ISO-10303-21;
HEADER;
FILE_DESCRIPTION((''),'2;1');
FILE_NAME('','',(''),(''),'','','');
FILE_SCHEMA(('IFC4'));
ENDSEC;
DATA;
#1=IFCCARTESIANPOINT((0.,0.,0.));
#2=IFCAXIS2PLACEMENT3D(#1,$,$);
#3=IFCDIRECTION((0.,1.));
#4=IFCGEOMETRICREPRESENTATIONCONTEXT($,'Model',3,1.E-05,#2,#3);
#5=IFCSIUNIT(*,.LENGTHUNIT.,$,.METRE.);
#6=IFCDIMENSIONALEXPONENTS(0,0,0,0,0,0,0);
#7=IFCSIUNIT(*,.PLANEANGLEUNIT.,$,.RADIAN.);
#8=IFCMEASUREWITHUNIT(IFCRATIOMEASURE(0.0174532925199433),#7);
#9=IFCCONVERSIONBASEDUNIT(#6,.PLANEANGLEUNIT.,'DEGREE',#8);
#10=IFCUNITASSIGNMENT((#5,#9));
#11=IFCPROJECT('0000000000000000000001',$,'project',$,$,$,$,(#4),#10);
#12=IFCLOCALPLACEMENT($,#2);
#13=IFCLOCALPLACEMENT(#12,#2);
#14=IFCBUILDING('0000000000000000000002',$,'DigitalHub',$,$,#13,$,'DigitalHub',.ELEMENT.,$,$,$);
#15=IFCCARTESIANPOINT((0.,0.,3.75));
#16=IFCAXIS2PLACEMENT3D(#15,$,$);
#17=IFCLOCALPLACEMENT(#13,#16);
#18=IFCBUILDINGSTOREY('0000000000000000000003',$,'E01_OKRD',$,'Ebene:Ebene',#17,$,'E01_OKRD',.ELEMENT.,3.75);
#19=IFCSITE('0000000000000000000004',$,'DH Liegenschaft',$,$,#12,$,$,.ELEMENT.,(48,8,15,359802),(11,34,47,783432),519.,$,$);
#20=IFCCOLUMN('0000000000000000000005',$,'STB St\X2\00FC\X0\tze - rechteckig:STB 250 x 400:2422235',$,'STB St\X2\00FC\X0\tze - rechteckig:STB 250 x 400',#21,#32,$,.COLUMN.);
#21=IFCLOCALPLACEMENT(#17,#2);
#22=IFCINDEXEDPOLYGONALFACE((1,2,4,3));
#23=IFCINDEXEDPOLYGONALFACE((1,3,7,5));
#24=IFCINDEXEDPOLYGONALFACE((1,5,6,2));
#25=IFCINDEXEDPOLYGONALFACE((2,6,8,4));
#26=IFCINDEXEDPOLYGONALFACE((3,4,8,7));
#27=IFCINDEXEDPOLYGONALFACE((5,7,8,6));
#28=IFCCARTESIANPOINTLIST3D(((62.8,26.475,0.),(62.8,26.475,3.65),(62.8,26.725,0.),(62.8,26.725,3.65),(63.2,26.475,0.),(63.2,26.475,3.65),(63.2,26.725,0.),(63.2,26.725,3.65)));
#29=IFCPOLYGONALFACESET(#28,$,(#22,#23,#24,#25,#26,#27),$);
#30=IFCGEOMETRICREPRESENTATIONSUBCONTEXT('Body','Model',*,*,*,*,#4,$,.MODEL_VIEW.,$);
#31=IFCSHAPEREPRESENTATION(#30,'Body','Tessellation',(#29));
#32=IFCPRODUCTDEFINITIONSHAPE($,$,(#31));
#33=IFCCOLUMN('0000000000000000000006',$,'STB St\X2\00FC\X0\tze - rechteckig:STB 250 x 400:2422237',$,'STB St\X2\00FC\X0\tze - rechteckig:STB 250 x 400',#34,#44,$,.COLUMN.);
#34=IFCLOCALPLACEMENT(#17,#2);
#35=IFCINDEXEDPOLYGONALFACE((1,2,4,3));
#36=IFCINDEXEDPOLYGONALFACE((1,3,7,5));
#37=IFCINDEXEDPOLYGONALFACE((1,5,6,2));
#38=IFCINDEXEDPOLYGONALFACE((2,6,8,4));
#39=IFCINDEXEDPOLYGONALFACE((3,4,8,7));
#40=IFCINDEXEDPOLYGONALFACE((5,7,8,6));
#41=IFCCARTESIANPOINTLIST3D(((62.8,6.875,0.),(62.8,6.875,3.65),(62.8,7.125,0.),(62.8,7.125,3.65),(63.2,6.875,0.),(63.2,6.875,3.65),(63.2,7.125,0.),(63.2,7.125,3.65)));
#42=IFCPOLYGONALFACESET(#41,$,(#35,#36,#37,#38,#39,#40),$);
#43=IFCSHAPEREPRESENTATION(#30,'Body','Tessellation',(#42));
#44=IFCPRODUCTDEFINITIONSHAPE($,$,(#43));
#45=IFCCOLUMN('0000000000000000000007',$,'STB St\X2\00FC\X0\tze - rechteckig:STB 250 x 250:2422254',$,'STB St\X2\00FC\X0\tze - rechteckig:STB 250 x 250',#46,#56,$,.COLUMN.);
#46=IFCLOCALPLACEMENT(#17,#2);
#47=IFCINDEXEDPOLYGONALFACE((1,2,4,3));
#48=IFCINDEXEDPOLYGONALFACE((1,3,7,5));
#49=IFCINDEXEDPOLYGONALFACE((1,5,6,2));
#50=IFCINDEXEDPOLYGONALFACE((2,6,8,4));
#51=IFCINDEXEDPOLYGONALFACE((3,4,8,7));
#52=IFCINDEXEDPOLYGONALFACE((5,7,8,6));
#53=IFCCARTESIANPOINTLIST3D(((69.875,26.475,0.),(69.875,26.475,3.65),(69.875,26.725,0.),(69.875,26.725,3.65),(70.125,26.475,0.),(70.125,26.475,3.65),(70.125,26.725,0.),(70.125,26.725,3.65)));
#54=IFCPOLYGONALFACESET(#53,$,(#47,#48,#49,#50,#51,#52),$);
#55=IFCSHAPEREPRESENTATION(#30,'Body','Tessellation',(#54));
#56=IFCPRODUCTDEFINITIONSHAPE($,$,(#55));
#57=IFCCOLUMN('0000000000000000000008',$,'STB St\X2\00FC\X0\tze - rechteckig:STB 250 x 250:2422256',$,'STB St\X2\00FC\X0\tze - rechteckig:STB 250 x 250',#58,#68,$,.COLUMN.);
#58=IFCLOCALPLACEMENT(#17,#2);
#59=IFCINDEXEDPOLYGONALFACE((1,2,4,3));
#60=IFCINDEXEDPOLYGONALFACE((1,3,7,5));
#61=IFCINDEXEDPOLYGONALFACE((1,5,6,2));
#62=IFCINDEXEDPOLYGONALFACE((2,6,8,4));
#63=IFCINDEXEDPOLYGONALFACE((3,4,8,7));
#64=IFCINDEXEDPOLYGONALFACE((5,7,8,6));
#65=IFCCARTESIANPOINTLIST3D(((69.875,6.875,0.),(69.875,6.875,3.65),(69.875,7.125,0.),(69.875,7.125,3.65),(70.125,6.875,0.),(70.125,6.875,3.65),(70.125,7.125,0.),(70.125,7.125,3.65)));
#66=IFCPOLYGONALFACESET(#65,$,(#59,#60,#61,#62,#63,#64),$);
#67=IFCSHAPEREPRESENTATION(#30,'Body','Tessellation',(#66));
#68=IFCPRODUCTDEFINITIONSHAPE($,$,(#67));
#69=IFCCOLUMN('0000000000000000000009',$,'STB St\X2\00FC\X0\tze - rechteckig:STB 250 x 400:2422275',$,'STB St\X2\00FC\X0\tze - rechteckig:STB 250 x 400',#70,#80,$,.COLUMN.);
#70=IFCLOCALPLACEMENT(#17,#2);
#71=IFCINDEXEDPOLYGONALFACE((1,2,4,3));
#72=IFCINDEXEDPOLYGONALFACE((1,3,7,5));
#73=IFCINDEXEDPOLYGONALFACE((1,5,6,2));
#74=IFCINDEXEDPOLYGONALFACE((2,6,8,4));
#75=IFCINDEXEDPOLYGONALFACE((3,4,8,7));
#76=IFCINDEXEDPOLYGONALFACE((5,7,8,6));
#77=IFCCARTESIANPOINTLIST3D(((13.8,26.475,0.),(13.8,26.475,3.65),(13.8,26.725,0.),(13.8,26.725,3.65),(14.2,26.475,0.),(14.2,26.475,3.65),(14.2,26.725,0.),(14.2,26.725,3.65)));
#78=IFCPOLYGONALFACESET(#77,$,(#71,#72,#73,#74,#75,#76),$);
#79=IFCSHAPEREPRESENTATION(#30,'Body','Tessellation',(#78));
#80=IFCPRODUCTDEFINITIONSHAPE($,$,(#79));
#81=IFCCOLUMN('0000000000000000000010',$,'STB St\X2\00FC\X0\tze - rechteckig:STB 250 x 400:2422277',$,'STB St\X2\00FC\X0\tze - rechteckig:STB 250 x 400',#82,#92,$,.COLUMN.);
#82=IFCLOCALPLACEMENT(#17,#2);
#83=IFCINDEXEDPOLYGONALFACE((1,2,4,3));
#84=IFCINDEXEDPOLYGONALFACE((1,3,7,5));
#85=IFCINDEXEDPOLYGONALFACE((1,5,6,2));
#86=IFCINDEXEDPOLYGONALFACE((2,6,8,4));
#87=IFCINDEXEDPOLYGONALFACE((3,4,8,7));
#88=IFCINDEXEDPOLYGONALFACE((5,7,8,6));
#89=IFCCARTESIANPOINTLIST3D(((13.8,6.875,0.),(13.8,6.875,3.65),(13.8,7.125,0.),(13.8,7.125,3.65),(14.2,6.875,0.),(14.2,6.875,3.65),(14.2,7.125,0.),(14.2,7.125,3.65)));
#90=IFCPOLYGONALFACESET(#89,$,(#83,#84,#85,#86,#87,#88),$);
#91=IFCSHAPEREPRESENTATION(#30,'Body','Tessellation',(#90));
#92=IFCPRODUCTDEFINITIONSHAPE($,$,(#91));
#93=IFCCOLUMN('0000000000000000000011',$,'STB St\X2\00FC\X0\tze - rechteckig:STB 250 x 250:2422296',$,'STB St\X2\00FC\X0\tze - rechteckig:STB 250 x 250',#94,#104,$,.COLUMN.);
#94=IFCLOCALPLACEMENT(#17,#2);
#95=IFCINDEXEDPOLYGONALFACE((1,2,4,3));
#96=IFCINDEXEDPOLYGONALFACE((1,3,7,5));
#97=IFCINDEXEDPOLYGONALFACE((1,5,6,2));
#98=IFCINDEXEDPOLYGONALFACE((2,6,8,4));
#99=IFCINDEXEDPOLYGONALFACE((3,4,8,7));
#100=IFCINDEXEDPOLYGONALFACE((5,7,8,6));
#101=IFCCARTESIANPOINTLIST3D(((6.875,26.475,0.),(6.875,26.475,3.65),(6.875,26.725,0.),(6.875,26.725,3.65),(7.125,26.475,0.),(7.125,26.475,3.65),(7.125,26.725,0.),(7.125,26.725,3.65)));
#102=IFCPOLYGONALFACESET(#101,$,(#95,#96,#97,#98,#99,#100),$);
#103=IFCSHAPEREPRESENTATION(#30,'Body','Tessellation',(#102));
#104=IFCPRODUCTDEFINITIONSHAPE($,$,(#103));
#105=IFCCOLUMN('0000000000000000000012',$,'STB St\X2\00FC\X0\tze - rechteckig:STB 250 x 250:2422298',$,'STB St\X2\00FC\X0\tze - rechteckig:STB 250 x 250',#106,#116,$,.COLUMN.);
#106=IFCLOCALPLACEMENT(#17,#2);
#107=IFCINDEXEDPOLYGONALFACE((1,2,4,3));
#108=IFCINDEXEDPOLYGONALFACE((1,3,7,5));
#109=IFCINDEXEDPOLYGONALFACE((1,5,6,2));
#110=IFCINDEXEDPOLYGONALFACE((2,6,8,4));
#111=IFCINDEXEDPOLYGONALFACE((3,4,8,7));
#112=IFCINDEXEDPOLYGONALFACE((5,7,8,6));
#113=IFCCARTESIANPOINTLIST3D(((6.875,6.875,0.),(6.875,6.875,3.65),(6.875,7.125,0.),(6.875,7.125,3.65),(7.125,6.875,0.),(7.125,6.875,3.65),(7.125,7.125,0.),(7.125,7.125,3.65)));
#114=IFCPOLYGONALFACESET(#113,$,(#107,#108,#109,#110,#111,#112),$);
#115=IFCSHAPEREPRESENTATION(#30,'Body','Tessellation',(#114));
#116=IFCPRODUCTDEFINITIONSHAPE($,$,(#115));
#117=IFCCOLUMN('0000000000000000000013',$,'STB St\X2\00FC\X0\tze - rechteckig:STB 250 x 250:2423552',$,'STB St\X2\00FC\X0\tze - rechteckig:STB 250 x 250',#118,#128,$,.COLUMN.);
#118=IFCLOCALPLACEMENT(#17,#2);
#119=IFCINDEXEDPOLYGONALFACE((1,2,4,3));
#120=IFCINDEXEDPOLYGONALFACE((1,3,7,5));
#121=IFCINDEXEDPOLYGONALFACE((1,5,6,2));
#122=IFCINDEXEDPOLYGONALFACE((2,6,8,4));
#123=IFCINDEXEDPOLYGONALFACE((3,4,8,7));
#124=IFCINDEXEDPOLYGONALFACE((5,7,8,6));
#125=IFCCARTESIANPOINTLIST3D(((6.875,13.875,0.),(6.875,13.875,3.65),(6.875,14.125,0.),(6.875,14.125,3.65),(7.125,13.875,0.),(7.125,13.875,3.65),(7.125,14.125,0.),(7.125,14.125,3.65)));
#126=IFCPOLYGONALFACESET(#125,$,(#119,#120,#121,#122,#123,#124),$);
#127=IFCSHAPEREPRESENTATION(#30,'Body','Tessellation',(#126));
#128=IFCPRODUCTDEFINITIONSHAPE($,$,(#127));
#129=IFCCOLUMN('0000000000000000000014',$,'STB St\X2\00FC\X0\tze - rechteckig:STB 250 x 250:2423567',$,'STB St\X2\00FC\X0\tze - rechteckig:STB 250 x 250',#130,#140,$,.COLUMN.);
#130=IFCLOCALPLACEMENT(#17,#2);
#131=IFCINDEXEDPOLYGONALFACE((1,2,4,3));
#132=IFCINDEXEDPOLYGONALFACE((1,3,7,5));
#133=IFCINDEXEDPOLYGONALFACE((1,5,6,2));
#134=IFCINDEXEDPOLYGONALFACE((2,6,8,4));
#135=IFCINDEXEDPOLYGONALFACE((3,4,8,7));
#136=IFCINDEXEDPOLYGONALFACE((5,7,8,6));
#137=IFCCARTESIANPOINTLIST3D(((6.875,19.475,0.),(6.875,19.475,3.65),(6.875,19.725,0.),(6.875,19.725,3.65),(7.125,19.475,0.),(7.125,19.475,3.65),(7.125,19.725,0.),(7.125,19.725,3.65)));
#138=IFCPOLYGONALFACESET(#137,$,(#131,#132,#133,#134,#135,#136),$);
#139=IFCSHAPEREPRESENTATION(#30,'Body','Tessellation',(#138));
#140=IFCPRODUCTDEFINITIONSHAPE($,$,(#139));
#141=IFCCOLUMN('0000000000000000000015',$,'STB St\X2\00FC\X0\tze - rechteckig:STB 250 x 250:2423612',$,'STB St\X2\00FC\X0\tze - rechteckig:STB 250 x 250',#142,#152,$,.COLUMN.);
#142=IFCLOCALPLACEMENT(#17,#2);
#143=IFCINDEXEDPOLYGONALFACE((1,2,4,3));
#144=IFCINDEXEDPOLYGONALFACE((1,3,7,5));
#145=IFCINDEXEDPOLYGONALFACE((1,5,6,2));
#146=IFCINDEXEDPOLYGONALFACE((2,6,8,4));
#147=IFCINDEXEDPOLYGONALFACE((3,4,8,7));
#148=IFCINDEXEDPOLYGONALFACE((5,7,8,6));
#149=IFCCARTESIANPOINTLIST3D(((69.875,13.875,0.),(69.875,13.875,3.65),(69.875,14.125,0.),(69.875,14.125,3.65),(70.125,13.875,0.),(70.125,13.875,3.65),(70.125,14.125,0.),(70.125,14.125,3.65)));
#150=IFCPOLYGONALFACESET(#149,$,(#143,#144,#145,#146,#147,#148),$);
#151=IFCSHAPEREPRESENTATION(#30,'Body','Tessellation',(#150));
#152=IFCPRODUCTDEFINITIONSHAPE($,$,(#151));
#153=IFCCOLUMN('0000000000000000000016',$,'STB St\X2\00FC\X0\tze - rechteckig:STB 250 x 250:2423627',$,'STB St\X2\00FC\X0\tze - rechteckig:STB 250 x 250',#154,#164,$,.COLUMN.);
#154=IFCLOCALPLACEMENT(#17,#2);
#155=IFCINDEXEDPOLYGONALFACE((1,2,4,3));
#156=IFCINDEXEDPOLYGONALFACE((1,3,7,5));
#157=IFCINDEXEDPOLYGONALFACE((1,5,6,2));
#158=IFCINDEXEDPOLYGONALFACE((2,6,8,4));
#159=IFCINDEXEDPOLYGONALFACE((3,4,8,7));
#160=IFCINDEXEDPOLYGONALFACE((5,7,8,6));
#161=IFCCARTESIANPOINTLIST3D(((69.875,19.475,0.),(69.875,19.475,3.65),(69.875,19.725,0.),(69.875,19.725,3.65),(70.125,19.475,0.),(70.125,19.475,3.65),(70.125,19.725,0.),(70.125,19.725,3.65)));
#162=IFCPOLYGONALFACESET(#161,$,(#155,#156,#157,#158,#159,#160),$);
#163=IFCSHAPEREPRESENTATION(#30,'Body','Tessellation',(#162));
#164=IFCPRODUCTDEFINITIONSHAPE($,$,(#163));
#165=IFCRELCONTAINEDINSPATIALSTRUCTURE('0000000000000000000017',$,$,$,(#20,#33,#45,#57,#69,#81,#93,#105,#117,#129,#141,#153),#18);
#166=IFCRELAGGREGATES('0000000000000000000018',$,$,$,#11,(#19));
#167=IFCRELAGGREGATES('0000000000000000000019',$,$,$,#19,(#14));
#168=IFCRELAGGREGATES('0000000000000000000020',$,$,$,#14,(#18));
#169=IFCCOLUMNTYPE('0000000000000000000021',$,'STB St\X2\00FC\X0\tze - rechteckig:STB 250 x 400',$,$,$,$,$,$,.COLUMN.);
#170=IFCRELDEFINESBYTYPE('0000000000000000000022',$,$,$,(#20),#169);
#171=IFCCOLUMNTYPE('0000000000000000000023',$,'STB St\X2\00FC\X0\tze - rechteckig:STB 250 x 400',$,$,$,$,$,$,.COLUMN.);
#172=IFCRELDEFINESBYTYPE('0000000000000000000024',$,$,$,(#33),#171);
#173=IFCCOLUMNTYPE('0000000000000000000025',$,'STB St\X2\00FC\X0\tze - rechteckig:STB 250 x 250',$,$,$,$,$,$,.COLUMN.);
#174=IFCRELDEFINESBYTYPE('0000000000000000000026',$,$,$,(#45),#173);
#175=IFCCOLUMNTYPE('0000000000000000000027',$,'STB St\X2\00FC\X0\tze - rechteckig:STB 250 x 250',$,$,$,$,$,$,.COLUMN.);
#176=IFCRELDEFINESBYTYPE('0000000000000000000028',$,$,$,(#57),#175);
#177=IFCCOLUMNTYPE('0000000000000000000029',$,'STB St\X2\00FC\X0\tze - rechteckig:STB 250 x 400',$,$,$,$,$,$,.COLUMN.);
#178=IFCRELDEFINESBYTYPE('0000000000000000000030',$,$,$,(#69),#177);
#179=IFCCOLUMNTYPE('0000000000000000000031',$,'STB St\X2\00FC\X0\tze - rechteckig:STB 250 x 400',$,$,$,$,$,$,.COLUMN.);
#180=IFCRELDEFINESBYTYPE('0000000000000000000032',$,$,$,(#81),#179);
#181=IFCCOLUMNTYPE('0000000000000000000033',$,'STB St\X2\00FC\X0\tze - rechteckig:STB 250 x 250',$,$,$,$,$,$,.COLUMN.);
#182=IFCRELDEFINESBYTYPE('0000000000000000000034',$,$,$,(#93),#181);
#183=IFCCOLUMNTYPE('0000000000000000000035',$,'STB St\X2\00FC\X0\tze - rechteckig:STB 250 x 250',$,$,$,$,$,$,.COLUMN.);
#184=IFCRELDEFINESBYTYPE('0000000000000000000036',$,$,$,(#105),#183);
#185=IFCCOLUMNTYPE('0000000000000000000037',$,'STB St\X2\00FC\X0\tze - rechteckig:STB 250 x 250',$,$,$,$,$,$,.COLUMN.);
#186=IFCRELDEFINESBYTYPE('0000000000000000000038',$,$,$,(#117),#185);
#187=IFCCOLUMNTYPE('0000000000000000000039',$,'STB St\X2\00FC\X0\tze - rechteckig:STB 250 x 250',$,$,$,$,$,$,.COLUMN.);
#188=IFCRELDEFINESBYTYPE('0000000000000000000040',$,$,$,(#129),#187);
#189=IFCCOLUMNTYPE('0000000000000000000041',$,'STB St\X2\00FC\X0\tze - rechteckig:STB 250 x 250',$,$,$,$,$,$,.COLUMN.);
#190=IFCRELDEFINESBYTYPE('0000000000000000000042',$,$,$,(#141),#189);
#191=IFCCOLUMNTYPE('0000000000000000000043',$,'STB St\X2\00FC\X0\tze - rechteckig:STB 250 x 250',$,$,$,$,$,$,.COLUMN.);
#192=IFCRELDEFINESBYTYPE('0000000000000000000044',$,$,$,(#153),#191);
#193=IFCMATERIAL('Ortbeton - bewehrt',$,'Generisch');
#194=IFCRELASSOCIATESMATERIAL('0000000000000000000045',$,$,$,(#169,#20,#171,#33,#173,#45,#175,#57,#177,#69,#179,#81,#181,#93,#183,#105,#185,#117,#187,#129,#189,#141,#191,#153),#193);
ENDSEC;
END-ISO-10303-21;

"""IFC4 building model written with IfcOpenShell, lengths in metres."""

from ifc_helpers import new_model, entity, si_unit, converted_unit, direction, frame, origin, place, context, subcontext, project, spatial, indexed_curve, outline, extrude, source, transform, mapped, material, type_object, type_shapes, element, save


model = new_model("IFC4")

# Units and contexts
model_context = context("Model", 3, precision=1e-05, world=origin(), true_north=direction((0.0, 1.0)))
body_context = subcontext(model_context, "Body", "Model", "MODEL_VIEW")
ifc_project = project(units=[si_unit("LENGTHUNIT", "METRE"), converted_unit("PLANEANGLEUNIT", "DEGREE", entity("IfcRatioMeasure", 0.0174532925199433), si_unit("PLANEANGLEUNIT", "RADIAN"), dimensions=[0, 0, 0, 0, 0, 0, 0])], contexts=[model_context])

# Site, building, storey
site_placement = place(None, frame((0.0, 0.0, 0.0)))
site = spatial("IfcSite", under=ifc_project, at=site_placement, Name="DH Liegenschaft", CompositionType="ELEMENT", RefLatitude=(48, 8, 15, 359802), RefLongitude=(11, 34, 47, 783432), RefElevation=519.0)
building_placement = place(site_placement, origin())
building = spatial("IfcBuilding", under=site, at=building_placement, Name="DigitalHub", LongName="DigitalHub", CompositionType="ELEMENT")
storey_placement = place(building_placement, frame((0.0, 0.0, 3.75)))
storey = spatial("IfcBuildingStorey", under=building, at=storey_placement, Name="E01_OKRD", ObjectType="Ebene:Ebene", LongName="E01_OKRD", CompositionType="ELEMENT", Elevation=3.75)

# Columns
ifc_material_1 = material(Name="Ortbeton - bewehrt", Category="Generisch")
column_type_1 = type_object("IfcColumnType", Name="STB Stütze - rechteckig:STB 250 x 400", PredefinedType="COLUMN", material=ifc_material_1)
shared_shape_1 = source(origin(), body_context, "Body", "SweptSolid", [
    extrude(outline(indexed_curve([(-0.125, -0.2), (0.125, -0.2), (0.125, 0.2), (-0.125, 0.2), (-0.125, -0.2)], self_intersect=False)), frame((63.0, 26.6, 3.75), z_axis=(0.0, 0.0, 1.0), x_axis=(0.0, -1.0, 0.0)), (0.0, 0.0, 1.0), 3.65),
])
type_shapes(column_type_1, [shared_shape_1])
column_1_placement = place(storey_placement, frame((0.0, 0.0, -3.75)))
element("IfcColumn", 1, at=column_1_placement, inside=storey, type_object=column_type_1, material=ifc_material_1, Name="STB Stütze - rechteckig:STB 250 x 400:2422235", ObjectType="STB Stütze - rechteckig:STB 250 x 400", PredefinedType="COLUMN", context=body_context, shape_type="MappedRepresentation", body=[
    mapped(shared_shape_1, transform((0.0, 0.0, 0.0), scale=1.0)),
])
column_type_2 = type_object("IfcColumnType", Name="STB Stütze - rechteckig:STB 250 x 400", PredefinedType="COLUMN", material=ifc_material_1)
shared_shape_2 = source(origin(), body_context, "Body", "SweptSolid", [
    extrude(outline(indexed_curve([(-0.125, -0.2), (0.125, -0.2), (0.125, 0.2), (-0.125, 0.2), (-0.125, -0.2)], self_intersect=False)), frame((63.0, 7.0, 3.75), z_axis=(0.0, 0.0, 1.0), x_axis=(0.0, -1.0, 0.0)), (0.0, 0.0, 1.0), 3.65),
])
type_shapes(column_type_2, [shared_shape_2])
column_2_placement = place(storey_placement, frame((0.0, 0.0, -3.75)))
element("IfcColumn", 2, at=column_2_placement, inside=storey, type_object=column_type_2, material=ifc_material_1, Name="STB Stütze - rechteckig:STB 250 x 400:2422237", ObjectType="STB Stütze - rechteckig:STB 250 x 400", PredefinedType="COLUMN", context=body_context, shape_type="MappedRepresentation", body=[
    mapped(shared_shape_2, transform((0.0, 0.0, 0.0), scale=1.0)),
])
column_type_3 = type_object("IfcColumnType", Name="STB Stütze - rechteckig:STB 250 x 250", PredefinedType="COLUMN", material=ifc_material_1)
shared_shape_3 = source(origin(), body_context, "Body", "SweptSolid", [
    extrude(outline(indexed_curve([(-0.125, -0.125), (0.125, -0.125), (0.125, 0.125), (-0.125, 0.125), (-0.125, -0.125)], self_intersect=False)), frame((70.0, 26.6, 3.75), z_axis=(0.0, 0.0, 1.0), x_axis=(0.0, -1.0, 0.0)), (0.0, 0.0, 1.0), 3.65),
])
type_shapes(column_type_3, [shared_shape_3])
column_3_placement = place(storey_placement, frame((0.0, 0.0, -3.75)))
element("IfcColumn", 3, at=column_3_placement, inside=storey, type_object=column_type_3, material=ifc_material_1, Name="STB Stütze - rechteckig:STB 250 x 250:2422254", ObjectType="STB Stütze - rechteckig:STB 250 x 250", PredefinedType="COLUMN", context=body_context, shape_type="MappedRepresentation", body=[
    mapped(shared_shape_3, transform((0.0, 0.0, 0.0), scale=1.0)),
])
column_type_4 = type_object("IfcColumnType", Name="STB Stütze - rechteckig:STB 250 x 250", PredefinedType="COLUMN", material=ifc_material_1)
shared_shape_4 = source(origin(), body_context, "Body", "SweptSolid", [
    extrude(outline(indexed_curve([(-0.125, -0.125), (0.125, -0.125), (0.125, 0.125), (-0.125, 0.125), (-0.125, -0.125)], self_intersect=False)), frame((70.0, 7.0, 3.75), z_axis=(0.0, 0.0, 1.0), x_axis=(0.0, -1.0, 0.0)), (0.0, 0.0, 1.0), 3.65),
])
type_shapes(column_type_4, [shared_shape_4])
column_4_placement = place(storey_placement, frame((0.0, 0.0, -3.75)))
element("IfcColumn", 4, at=column_4_placement, inside=storey, type_object=column_type_4, material=ifc_material_1, Name="STB Stütze - rechteckig:STB 250 x 250:2422256", ObjectType="STB Stütze - rechteckig:STB 250 x 250", PredefinedType="COLUMN", context=body_context, shape_type="MappedRepresentation", body=[
    mapped(shared_shape_4, transform((0.0, 0.0, 0.0), scale=1.0)),
])
column_type_5 = type_object("IfcColumnType", Name="STB Stütze - rechteckig:STB 250 x 400", PredefinedType="COLUMN", material=ifc_material_1)
shared_shape_5 = source(origin(), body_context, "Body", "SweptSolid", [
    extrude(outline(indexed_curve([(-0.125, -0.2), (0.125, -0.2), (0.125, 0.2), (-0.125, 0.2), (-0.125, -0.2)], self_intersect=False)), frame((14.0, 26.6, 3.75), z_axis=(0.0, 0.0, 1.0), x_axis=(0.0, -1.0, 0.0)), (0.0, 0.0, 1.0), 3.65),
])
type_shapes(column_type_5, [shared_shape_5])
column_5_placement = place(storey_placement, frame((0.0, 0.0, -3.75)))
element("IfcColumn", 5, at=column_5_placement, inside=storey, type_object=column_type_5, material=ifc_material_1, Name="STB Stütze - rechteckig:STB 250 x 400:2422275", ObjectType="STB Stütze - rechteckig:STB 250 x 400", PredefinedType="COLUMN", context=body_context, shape_type="MappedRepresentation", body=[
    mapped(shared_shape_5, transform((0.0, 0.0, 0.0), scale=1.0)),
])
column_type_6 = type_object("IfcColumnType", Name="STB Stütze - rechteckig:STB 250 x 400", PredefinedType="COLUMN", material=ifc_material_1)
shared_shape_6 = source(origin(), body_context, "Body", "SweptSolid", [
    extrude(outline(indexed_curve([(-0.125, -0.2), (0.125, -0.2), (0.125, 0.2), (-0.125, 0.2), (-0.125, -0.2)], self_intersect=False)), frame((14.0, 7.0, 3.75), z_axis=(0.0, 0.0, 1.0), x_axis=(0.0, -1.0, 0.0)), (0.0, 0.0, 1.0), 3.65),
])
type_shapes(column_type_6, [shared_shape_6])
column_6_placement = place(storey_placement, frame((0.0, 0.0, -3.75)))
element("IfcColumn", 6, at=column_6_placement, inside=storey, type_object=column_type_6, material=ifc_material_1, Name="STB Stütze - rechteckig:STB 250 x 400:2422277", ObjectType="STB Stütze - rechteckig:STB 250 x 400", PredefinedType="COLUMN", context=body_context, shape_type="MappedRepresentation", body=[
    mapped(shared_shape_6, transform((0.0, 0.0, 0.0), scale=1.0)),
])
column_type_7 = type_object("IfcColumnType", Name="STB Stütze - rechteckig:STB 250 x 250", PredefinedType="COLUMN", material=ifc_material_1)
shared_shape_7 = source(origin(), body_context, "Body", "SweptSolid", [
    extrude(outline(indexed_curve([(-0.125, -0.125), (0.125, -0.125), (0.125, 0.125), (-0.125, 0.125), (-0.125, -0.125)], self_intersect=False)), frame((7.0, 26.6, 3.75), z_axis=(0.0, 0.0, 1.0), x_axis=(0.0, -1.0, 0.0)), (0.0, 0.0, 1.0), 3.65),
])
type_shapes(column_type_7, [shared_shape_7])
column_7_placement = place(storey_placement, frame((0.0, 0.0, -3.75)))
element("IfcColumn", 7, at=column_7_placement, inside=storey, type_object=column_type_7, material=ifc_material_1, Name="STB Stütze - rechteckig:STB 250 x 250:2422296", ObjectType="STB Stütze - rechteckig:STB 250 x 250", PredefinedType="COLUMN", context=body_context, shape_type="MappedRepresentation", body=[
    mapped(shared_shape_7, transform((0.0, 0.0, 0.0), scale=1.0)),
])
column_type_8 = type_object("IfcColumnType", Name="STB Stütze - rechteckig:STB 250 x 250", PredefinedType="COLUMN", material=ifc_material_1)
shared_shape_8 = source(origin(), body_context, "Body", "SweptSolid", [
    extrude(outline(indexed_curve([(-0.125, -0.125), (0.125, -0.125), (0.125, 0.125), (-0.125, 0.125), (-0.125, -0.125)], self_intersect=False)), frame((7.0, 7.0, 3.75), z_axis=(0.0, 0.0, 1.0), x_axis=(0.0, -1.0, 0.0)), (0.0, 0.0, 1.0), 3.65),
])
type_shapes(column_type_8, [shared_shape_8])
column_8_placement = place(storey_placement, frame((0.0, 0.0, -3.75)))
element("IfcColumn", 8, at=column_8_placement, inside=storey, type_object=column_type_8, material=ifc_material_1, Name="STB Stütze - rechteckig:STB 250 x 250:2422298", ObjectType="STB Stütze - rechteckig:STB 250 x 250", PredefinedType="COLUMN", context=body_context, shape_type="MappedRepresentation", body=[
    mapped(shared_shape_8, transform((0.0, 0.0, 0.0), scale=1.0)),
])
column_type_9 = type_object("IfcColumnType", Name="STB Stütze - rechteckig:STB 250 x 250", PredefinedType="COLUMN", material=ifc_material_1)
shared_shape_9 = source(origin(), body_context, "Body", "SweptSolid", [
    extrude(outline(indexed_curve([(-0.125, -0.125), (0.125, -0.125), (0.125, 0.125), (-0.125, 0.125), (-0.125, -0.125)], self_intersect=False)), frame((7.0, 14.0, 3.75), z_axis=(0.0, 0.0, 1.0), x_axis=(0.0, -1.0, 0.0)), (0.0, 0.0, 1.0), 3.65),
])
type_shapes(column_type_9, [shared_shape_9])
column_9_placement = place(storey_placement, frame((0.0, 0.0, -3.75)))
element("IfcColumn", 9, at=column_9_placement, inside=storey, type_object=column_type_9, material=ifc_material_1, Name="STB Stütze - rechteckig:STB 250 x 250:2423552", ObjectType="STB Stütze - rechteckig:STB 250 x 250", PredefinedType="COLUMN", context=body_context, shape_type="MappedRepresentation", body=[
    mapped(shared_shape_9, transform((0.0, 0.0, 0.0), scale=1.0)),
])
column_type_10 = type_object("IfcColumnType", Name="STB Stütze - rechteckig:STB 250 x 250", PredefinedType="COLUMN", material=ifc_material_1)
shared_shape_10 = source(origin(), body_context, "Body", "SweptSolid", [
    extrude(outline(indexed_curve([(-0.125, -0.125), (0.125, -0.125), (0.125, 0.125), (-0.125, 0.125), (-0.125, -0.125)], self_intersect=False)), frame((7.0, 19.6, 3.75), z_axis=(0.0, 0.0, 1.0), x_axis=(0.0, -1.0, 0.0)), (0.0, 0.0, 1.0), 3.65),
])
type_shapes(column_type_10, [shared_shape_10])
column_10_placement = place(storey_placement, frame((0.0, 0.0, -3.75)))
element("IfcColumn", 10, at=column_10_placement, inside=storey, type_object=column_type_10, material=ifc_material_1, Name="STB Stütze - rechteckig:STB 250 x 250:2423567", ObjectType="STB Stütze - rechteckig:STB 250 x 250", PredefinedType="COLUMN", context=body_context, shape_type="MappedRepresentation", body=[
    mapped(shared_shape_10, transform((0.0, 0.0, 0.0), scale=1.0)),
])
column_type_11 = type_object("IfcColumnType", Name="STB Stütze - rechteckig:STB 250 x 250", PredefinedType="COLUMN", material=ifc_material_1)
shared_shape_11 = source(origin(), body_context, "Body", "SweptSolid", [
    extrude(outline(indexed_curve([(-0.125, -0.125), (0.125, -0.125), (0.125, 0.125), (-0.125, 0.125), (-0.125, -0.125)], self_intersect=False)), frame((70.0, 14.0, 3.75), z_axis=(0.0, 0.0, 1.0), x_axis=(0.0, -1.0, 0.0)), (0.0, 0.0, 1.0), 3.65),
])
type_shapes(column_type_11, [shared_shape_11])
column_11_placement = place(storey_placement, frame((0.0, 0.0, -3.75)))
element("IfcColumn", 11, at=column_11_placement, inside=storey, type_object=column_type_11, material=ifc_material_1, Name="STB Stütze - rechteckig:STB 250 x 250:2423612", ObjectType="STB Stütze - rechteckig:STB 250 x 250", PredefinedType="COLUMN", context=body_context, shape_type="MappedRepresentation", body=[
    mapped(shared_shape_11, transform((0.0, 0.0, 0.0), scale=1.0)),
])
column_type_12 = type_object("IfcColumnType", Name="STB Stütze - rechteckig:STB 250 x 250", PredefinedType="COLUMN", material=ifc_material_1)
shared_shape_12 = source(origin(), body_context, "Body", "SweptSolid", [
    extrude(outline(indexed_curve([(-0.125, -0.125), (0.125, -0.125), (0.125, 0.125), (-0.125, 0.125), (-0.125, -0.125)], self_intersect=False)), frame((70.0, 19.6, 3.75), z_axis=(0.0, 0.0, 1.0), x_axis=(0.0, -1.0, 0.0)), (0.0, 0.0, 1.0), 3.65),
])
type_shapes(column_type_12, [shared_shape_12])
column_12_placement = place(storey_placement, frame((0.0, 0.0, -3.75)))
element("IfcColumn", 12, at=column_12_placement, inside=storey, type_object=column_type_12, material=ifc_material_1, Name="STB Stütze - rechteckig:STB 250 x 250:2423627", ObjectType="STB Stütze - rechteckig:STB 250 x 250", PredefinedType="COLUMN", context=body_context, shape_type="MappedRepresentation", body=[
    mapped(shared_shape_12, transform((0.0, 0.0, 0.0), scale=1.0)),
])

save(model, "model.ifc")
